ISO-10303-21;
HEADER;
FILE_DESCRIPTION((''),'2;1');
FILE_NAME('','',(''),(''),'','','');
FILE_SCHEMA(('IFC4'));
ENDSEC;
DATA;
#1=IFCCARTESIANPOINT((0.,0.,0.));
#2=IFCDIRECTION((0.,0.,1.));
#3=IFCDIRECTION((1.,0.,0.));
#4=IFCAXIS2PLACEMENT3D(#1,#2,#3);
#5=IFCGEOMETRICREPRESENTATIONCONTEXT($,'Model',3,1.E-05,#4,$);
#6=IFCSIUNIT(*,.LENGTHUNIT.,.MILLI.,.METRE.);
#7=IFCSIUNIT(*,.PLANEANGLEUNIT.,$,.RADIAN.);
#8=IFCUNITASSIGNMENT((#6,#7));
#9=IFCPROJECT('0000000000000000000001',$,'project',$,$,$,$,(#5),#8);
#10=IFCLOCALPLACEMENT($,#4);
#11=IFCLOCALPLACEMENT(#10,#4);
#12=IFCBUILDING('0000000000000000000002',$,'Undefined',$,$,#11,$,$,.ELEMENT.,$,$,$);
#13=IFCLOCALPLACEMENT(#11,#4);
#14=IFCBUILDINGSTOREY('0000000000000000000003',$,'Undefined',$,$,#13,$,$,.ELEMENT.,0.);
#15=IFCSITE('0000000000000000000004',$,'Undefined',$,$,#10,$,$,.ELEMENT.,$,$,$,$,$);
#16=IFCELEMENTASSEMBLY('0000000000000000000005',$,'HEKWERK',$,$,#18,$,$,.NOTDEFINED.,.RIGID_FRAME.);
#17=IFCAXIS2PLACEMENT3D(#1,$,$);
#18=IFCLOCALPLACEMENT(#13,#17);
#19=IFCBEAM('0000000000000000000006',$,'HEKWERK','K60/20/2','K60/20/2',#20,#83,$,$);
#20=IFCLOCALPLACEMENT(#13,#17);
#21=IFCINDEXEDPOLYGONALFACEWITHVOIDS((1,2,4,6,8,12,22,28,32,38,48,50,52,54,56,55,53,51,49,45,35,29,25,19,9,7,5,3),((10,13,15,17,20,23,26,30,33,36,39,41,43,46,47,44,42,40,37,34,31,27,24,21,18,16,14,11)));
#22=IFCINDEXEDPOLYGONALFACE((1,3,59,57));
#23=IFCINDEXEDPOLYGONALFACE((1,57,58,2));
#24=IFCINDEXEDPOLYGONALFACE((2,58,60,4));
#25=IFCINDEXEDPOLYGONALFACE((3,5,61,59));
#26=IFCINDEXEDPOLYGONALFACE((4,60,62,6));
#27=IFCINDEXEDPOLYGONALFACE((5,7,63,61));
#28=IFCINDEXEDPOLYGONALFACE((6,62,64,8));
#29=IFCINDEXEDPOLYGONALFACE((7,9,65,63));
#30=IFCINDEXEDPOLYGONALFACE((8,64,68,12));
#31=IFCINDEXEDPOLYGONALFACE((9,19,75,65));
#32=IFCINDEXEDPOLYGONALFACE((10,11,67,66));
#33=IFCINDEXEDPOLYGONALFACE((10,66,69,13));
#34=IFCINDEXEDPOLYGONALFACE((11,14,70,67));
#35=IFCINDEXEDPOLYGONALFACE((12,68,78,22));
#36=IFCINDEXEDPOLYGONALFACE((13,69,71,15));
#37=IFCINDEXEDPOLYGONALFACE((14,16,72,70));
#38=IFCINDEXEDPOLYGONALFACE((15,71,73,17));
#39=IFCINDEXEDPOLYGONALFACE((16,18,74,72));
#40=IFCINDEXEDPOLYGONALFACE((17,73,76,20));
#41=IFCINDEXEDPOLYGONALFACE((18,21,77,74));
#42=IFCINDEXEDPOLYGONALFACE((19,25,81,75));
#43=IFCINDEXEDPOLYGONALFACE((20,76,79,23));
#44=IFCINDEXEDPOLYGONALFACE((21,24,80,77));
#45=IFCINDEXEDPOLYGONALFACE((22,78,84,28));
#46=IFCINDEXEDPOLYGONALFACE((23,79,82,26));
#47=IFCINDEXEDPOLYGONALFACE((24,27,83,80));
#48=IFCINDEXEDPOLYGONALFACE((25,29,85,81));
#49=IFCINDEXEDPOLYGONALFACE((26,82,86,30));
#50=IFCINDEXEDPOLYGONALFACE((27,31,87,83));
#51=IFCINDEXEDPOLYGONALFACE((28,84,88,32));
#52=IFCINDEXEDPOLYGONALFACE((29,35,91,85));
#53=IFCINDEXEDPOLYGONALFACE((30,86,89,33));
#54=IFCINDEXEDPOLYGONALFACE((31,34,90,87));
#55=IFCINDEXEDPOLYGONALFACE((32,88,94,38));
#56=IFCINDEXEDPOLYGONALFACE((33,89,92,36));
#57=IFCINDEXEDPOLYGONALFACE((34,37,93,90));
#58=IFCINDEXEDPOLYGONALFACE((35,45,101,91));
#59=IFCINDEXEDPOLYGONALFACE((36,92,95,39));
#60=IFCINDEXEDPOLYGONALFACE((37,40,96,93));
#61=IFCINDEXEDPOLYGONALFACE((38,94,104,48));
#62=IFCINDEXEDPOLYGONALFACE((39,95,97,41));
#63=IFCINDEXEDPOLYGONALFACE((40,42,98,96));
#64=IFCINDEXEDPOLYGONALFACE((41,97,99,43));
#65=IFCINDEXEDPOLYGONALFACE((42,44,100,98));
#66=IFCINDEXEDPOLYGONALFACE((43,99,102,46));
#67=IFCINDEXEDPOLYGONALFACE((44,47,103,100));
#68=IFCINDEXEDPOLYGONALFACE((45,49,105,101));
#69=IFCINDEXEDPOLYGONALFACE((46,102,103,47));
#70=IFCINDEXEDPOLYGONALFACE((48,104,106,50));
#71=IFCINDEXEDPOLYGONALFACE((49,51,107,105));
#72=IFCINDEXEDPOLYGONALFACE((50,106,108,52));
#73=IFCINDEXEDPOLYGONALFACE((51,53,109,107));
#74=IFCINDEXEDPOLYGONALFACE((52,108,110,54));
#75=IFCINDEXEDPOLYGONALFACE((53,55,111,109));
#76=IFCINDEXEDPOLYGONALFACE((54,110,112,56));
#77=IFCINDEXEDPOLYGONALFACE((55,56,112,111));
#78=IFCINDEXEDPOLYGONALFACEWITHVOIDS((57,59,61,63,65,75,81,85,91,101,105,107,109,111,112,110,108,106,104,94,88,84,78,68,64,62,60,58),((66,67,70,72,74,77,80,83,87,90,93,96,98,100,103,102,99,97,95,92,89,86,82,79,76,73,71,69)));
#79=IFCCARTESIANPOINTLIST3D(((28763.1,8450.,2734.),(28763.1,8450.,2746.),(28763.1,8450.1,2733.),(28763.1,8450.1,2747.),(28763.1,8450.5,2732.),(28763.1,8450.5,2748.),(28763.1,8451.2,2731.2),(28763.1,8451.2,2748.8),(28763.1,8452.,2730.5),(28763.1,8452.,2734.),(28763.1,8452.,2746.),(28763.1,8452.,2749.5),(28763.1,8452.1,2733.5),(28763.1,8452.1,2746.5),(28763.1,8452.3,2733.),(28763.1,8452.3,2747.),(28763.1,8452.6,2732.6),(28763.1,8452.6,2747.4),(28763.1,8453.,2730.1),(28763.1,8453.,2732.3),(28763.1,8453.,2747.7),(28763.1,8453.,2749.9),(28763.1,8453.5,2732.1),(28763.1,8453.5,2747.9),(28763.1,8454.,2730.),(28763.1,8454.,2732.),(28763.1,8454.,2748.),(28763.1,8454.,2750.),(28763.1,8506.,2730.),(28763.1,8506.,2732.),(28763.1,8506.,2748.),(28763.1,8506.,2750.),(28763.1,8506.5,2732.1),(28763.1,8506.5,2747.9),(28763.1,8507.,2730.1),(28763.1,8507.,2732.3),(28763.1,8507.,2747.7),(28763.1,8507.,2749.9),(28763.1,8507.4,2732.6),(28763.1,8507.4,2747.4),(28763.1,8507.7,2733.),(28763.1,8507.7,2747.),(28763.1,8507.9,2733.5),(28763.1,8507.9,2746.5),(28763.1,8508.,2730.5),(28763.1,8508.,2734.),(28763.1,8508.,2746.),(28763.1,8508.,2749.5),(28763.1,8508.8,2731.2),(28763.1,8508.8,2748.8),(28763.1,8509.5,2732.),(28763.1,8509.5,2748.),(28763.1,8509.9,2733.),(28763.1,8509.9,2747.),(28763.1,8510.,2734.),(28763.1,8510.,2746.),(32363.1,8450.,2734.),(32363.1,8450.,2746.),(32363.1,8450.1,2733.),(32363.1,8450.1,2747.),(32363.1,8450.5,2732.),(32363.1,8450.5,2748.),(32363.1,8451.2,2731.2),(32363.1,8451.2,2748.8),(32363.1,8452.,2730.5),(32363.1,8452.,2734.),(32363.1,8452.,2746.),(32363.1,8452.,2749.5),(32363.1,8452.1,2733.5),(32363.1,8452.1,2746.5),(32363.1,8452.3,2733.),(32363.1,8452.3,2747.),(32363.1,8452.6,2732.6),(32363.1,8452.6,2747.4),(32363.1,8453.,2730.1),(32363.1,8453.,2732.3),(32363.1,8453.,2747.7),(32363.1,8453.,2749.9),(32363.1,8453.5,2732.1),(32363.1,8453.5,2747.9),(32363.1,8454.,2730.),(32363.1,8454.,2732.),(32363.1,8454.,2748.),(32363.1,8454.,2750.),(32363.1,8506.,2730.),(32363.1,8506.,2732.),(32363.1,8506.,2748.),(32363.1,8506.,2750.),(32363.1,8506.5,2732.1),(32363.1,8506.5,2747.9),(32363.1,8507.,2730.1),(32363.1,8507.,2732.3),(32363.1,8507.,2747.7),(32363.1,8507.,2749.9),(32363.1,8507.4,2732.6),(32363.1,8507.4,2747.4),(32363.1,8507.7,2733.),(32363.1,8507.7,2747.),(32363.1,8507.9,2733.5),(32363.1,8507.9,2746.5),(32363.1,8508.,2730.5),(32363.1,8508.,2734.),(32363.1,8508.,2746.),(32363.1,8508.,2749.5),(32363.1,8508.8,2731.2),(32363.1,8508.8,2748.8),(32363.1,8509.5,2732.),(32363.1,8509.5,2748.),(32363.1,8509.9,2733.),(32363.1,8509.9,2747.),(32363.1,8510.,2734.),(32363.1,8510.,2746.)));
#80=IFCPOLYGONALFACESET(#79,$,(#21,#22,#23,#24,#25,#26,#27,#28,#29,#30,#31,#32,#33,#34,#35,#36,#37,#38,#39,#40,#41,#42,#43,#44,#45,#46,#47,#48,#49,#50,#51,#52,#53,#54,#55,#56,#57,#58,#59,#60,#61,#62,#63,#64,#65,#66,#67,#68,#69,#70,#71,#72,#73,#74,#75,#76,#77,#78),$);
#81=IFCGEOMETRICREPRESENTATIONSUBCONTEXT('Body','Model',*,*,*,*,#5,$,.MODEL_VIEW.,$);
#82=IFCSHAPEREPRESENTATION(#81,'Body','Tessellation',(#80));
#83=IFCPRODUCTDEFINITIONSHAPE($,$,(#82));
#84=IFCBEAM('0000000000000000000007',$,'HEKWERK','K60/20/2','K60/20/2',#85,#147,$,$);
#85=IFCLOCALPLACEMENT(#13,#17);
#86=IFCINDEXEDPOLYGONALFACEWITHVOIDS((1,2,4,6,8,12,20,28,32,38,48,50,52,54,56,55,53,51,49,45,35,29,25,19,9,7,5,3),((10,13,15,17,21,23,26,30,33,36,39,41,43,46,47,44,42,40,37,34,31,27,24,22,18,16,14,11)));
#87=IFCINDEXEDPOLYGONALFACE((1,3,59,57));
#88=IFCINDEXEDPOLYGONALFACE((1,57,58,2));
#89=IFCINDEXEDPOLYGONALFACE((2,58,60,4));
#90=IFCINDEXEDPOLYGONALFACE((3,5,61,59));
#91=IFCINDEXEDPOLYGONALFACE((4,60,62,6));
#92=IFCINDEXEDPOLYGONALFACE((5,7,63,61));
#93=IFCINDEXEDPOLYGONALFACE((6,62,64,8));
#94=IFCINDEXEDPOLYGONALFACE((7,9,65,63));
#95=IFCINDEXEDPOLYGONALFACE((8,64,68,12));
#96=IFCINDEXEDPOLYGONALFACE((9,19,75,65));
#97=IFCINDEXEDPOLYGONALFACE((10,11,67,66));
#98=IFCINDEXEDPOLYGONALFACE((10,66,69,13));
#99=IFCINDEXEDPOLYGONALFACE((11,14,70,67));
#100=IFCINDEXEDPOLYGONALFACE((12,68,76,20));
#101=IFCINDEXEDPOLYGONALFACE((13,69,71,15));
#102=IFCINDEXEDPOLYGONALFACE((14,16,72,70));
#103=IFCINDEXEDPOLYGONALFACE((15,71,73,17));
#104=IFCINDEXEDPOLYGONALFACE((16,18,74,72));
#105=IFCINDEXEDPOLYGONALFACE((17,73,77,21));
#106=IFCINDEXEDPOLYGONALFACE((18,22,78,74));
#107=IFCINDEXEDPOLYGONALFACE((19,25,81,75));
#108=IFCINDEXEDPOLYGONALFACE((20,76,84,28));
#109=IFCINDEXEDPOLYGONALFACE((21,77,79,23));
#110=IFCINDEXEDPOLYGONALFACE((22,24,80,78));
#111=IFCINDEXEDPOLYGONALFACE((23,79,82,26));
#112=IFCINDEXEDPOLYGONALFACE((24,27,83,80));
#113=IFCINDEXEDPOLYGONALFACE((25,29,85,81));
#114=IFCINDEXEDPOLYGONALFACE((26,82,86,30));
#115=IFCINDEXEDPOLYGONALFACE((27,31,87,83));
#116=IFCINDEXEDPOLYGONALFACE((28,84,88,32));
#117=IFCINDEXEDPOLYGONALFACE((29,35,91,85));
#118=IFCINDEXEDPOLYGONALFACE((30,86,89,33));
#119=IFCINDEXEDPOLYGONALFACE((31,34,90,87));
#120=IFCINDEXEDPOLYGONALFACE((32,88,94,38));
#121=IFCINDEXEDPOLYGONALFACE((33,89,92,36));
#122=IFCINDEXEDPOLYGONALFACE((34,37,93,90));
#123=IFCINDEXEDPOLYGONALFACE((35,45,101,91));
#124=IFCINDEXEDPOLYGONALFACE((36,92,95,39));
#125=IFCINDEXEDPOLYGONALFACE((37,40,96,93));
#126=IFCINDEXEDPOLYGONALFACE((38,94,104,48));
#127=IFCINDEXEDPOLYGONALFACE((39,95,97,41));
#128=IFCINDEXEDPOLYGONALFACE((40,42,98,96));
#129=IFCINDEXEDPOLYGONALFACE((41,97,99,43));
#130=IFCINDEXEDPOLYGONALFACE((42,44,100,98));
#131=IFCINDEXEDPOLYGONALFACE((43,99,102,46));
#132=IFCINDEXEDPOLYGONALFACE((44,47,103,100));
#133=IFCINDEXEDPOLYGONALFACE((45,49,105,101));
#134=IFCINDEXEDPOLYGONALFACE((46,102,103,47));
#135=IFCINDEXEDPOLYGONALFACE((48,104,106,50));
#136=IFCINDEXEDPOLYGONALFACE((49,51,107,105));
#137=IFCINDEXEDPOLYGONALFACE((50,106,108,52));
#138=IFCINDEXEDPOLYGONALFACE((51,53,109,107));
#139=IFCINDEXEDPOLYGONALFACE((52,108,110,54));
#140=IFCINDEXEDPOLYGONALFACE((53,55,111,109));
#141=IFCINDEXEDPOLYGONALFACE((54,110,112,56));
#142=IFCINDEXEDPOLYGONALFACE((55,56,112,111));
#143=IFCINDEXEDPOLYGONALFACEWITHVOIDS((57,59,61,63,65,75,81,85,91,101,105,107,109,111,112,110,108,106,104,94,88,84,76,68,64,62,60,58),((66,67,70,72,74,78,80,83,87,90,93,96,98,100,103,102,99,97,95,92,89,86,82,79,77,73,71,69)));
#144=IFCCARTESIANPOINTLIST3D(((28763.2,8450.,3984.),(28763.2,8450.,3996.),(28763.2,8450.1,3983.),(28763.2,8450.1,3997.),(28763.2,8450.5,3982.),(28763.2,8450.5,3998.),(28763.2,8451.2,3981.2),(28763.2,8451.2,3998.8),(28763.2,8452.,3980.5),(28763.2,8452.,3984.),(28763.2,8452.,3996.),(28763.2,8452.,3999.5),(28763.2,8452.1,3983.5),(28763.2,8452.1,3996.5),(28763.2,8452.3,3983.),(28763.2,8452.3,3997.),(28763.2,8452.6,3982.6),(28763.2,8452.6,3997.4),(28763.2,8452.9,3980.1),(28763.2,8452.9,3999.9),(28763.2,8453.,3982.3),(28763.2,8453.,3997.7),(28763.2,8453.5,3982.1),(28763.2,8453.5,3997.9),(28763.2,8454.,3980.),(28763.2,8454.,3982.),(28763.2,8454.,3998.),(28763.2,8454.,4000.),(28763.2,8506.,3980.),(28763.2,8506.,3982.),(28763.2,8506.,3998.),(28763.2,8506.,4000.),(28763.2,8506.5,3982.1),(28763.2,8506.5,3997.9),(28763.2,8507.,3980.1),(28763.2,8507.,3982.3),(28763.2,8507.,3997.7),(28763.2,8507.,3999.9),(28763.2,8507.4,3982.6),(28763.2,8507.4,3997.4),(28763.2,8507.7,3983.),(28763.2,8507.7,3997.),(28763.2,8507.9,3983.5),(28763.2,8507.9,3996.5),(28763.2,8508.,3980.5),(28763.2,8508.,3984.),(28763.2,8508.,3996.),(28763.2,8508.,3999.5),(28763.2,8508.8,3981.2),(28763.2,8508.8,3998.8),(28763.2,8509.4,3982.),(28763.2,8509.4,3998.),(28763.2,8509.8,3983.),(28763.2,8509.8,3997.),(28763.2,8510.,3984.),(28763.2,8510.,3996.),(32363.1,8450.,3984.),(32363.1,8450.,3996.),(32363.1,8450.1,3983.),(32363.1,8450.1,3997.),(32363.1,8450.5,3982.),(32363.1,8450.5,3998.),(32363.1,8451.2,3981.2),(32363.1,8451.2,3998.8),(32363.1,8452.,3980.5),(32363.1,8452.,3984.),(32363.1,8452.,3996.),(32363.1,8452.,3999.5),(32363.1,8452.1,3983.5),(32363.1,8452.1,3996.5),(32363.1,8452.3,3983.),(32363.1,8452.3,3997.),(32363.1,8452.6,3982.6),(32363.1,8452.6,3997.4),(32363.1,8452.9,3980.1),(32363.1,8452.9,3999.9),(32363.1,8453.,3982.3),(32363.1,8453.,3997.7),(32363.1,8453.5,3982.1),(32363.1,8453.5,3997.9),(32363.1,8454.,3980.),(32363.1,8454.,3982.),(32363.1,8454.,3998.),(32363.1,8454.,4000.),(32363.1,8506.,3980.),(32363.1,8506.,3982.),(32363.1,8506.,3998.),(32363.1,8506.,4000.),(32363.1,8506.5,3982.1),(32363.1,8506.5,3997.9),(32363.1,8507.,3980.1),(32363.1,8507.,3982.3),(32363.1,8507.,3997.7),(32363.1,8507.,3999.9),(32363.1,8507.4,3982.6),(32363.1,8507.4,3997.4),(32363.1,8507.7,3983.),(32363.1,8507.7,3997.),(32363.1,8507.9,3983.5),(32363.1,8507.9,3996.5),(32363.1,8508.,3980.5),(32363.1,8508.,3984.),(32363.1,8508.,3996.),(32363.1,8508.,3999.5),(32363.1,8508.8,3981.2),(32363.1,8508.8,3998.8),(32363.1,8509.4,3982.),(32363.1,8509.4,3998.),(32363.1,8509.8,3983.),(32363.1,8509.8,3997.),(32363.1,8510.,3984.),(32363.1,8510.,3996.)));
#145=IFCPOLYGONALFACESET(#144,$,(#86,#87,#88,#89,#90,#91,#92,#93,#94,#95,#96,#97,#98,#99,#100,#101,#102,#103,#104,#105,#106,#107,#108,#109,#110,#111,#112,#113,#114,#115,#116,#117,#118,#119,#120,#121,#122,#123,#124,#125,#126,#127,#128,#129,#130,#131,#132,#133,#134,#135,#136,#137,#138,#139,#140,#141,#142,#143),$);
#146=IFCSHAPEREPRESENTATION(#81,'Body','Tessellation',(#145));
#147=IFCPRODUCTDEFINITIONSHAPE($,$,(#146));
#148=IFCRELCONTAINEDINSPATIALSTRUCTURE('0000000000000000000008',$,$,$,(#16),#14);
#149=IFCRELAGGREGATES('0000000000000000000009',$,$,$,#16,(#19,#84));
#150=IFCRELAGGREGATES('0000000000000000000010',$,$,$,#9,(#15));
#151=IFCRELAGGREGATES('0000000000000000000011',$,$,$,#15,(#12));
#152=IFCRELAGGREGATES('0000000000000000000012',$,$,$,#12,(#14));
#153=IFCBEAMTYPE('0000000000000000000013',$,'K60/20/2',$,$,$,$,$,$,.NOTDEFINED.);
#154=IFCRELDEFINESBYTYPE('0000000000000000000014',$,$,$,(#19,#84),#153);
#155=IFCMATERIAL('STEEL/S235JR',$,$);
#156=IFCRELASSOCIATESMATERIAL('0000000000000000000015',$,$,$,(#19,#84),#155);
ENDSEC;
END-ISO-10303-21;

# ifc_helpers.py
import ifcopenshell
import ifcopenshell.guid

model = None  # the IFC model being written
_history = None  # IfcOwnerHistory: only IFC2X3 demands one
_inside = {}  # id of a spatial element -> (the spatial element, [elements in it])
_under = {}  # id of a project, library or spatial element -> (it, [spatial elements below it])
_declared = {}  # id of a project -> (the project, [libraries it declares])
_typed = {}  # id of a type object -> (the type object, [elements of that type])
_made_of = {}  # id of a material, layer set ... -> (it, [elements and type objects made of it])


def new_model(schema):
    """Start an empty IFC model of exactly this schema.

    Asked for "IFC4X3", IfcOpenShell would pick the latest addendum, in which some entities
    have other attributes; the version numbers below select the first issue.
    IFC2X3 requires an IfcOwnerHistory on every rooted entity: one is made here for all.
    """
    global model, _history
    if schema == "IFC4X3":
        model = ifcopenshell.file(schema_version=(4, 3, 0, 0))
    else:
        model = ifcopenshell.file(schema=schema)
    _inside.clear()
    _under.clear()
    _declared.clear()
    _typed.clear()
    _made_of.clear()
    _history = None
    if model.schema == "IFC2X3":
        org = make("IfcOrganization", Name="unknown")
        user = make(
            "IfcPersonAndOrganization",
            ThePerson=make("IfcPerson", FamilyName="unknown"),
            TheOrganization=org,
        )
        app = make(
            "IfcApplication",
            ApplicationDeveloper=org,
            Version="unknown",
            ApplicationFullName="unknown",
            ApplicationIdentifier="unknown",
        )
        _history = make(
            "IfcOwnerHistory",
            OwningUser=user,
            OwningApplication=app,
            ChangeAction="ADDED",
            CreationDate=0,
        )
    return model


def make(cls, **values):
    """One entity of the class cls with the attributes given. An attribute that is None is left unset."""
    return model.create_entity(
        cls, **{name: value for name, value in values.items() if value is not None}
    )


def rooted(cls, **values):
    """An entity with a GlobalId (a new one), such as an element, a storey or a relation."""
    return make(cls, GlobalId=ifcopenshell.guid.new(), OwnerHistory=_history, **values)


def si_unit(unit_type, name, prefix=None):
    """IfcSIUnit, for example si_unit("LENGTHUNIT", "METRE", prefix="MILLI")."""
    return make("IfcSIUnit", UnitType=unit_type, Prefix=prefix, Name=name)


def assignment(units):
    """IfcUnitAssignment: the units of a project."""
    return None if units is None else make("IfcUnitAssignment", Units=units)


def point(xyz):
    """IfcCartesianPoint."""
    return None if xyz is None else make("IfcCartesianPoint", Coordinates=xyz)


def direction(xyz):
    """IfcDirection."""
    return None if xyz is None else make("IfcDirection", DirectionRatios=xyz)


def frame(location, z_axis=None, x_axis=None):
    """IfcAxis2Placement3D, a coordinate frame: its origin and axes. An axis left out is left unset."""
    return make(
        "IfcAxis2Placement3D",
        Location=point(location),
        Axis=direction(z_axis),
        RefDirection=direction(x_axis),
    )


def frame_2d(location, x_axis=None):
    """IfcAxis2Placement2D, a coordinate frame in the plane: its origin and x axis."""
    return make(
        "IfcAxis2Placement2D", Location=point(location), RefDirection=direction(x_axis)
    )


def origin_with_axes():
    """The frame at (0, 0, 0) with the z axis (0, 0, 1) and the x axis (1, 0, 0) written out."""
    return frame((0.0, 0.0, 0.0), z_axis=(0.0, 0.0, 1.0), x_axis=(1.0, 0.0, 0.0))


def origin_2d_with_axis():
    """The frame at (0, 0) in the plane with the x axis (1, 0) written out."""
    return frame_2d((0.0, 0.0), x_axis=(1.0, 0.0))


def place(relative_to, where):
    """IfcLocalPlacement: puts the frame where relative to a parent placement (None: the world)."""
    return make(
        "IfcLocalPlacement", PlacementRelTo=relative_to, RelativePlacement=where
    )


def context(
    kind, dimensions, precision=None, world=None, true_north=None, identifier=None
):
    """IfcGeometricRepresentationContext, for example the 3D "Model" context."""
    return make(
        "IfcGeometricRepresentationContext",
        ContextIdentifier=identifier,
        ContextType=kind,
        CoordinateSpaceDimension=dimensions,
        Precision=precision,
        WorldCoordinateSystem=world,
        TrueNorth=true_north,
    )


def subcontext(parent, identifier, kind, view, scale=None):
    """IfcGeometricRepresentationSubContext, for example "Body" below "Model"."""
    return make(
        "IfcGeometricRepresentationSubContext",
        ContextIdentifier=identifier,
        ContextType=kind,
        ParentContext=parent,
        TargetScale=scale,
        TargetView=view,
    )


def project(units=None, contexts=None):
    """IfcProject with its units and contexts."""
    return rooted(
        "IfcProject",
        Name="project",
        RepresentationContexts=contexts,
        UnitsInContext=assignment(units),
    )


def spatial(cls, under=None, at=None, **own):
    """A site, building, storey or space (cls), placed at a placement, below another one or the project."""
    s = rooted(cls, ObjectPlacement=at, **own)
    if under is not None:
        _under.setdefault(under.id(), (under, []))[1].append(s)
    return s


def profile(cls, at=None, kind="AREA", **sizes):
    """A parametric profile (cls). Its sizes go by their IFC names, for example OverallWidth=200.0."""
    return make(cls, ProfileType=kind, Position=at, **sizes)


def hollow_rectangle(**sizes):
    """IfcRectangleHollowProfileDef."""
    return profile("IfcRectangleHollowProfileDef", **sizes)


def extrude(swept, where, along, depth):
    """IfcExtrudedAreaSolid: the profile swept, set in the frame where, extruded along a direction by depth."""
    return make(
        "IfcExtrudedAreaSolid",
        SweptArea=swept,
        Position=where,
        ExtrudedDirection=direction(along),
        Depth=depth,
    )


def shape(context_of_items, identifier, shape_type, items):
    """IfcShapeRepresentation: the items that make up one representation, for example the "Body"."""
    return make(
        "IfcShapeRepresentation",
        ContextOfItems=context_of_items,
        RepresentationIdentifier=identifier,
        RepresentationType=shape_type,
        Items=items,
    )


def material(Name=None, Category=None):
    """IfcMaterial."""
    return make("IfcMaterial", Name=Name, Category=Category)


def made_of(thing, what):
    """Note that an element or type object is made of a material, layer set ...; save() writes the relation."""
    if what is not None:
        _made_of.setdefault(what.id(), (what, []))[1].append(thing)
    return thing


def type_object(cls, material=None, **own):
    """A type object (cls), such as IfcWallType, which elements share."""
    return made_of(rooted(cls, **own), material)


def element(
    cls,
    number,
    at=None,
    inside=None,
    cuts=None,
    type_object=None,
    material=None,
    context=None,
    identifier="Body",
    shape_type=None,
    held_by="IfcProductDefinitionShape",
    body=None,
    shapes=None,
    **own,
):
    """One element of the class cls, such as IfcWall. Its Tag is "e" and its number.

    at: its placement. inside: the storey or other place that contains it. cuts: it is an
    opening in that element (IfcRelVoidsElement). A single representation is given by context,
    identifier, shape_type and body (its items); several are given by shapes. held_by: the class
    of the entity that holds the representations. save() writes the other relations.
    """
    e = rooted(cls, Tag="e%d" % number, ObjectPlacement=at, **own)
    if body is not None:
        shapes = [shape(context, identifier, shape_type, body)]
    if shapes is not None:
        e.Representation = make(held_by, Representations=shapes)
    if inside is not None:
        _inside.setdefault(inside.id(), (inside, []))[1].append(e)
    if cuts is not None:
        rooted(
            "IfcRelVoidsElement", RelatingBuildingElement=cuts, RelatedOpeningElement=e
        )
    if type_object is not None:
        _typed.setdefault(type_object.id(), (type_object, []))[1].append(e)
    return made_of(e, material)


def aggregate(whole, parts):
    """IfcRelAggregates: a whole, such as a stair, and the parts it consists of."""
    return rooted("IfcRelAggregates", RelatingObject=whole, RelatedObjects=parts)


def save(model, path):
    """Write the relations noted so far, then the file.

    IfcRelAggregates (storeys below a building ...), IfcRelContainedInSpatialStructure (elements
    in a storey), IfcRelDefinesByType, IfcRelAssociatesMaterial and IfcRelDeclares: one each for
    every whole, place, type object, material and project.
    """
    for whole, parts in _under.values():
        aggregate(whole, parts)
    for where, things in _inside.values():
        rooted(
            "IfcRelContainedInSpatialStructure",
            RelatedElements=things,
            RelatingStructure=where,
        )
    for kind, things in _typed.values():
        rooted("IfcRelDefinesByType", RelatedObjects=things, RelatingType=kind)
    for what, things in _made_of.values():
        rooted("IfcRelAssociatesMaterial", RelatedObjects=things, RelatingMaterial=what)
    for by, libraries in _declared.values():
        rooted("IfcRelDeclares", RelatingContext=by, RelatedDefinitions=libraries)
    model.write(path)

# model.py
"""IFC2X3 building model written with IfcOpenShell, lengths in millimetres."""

from ifc_helpers import new_model, si_unit, frame, origin_with_axes, origin_2d_with_axis, place, context, subcontext, project, spatial, hollow_rectangle, extrude, material, type_object, element, aggregate, save


model = new_model("IFC2X3")

# Units and contexts
model_context = context("Model", 3, precision=1e-05, world=origin_with_axes())
body_context = subcontext(model_context, "Body", "Model", "MODEL_VIEW")
ifc_project = project(units=[si_unit("LENGTHUNIT", "METRE", prefix="MILLI"), si_unit("PLANEANGLEUNIT", "RADIAN")], contexts=[model_context])

# Site, building, storey
site_placement = place(None, origin_with_axes())
site = spatial("IfcSite", under=ifc_project, at=site_placement, Name="Undefined", CompositionType="ELEMENT")
building_placement = place(site_placement, origin_with_axes())
building = spatial("IfcBuilding", under=site, at=building_placement, Name="Undefined", CompositionType="ELEMENT")
storey_placement = place(building_placement, origin_with_axes())
storey = spatial("IfcBuildingStorey", under=building, at=storey_placement, Name="Undefined", CompositionType="ELEMENT", Elevation=0.0)

# Element assembly, beams
assembly_1_placement = place(storey_placement, origin_with_axes())
assembly_1 = element("IfcElementAssembly", 1, at=assembly_1_placement, inside=storey, Name="HEKWERK", AssemblyPlace="NOTDEFINED", PredefinedType="RIGID_FRAME")
ifc_material_1 = material(Name="STEEL/S235JR")
beam_type_1 = type_object("IfcBeamType", Name="K60/20/2", PredefinedType="NOTDEFINED")
beam_1_placement = place(assembly_1_placement, frame((28763.1, 8480.0, 2740.0), z_axis=(0.0, 1.0, 0.0), x_axis=(1.0, 0.0, 0.0)))
beam_1 = element("IfcBeam", 2, at=beam_1_placement, type_object=beam_type_1, material=ifc_material_1, Name="HEKWERK", Description="K60/20/2", ObjectType="K60/20/2", context=body_context, shape_type="SweptSolid", body=[
    extrude(hollow_rectangle(XDim=20.0, YDim=60.0, WallThickness=2.0, InnerFilletRadius=2.0, OuterFilletRadius=4.0, at=origin_2d_with_axis()), frame((3600.0, 0.0, 0.0), z_axis=(-1.0, 0.0, 0.0), x_axis=(0.0, -1.0, 0.0)), (0.0, 0.0, 1.0), 3600.0),
])
beam_2_placement = place(assembly_1_placement, frame((28763.2, 8480.0, 3990.0), z_axis=(0.0, 1.0, 0.0), x_axis=(1.0, 0.0, 0.0)))
beam_2 = element("IfcBeam", 3, at=beam_2_placement, type_object=beam_type_1, material=ifc_material_1, Name="HEKWERK", Description="K60/20/2", ObjectType="K60/20/2", context=body_context, shape_type="SweptSolid", body=[
    extrude(hollow_rectangle(XDim=20.0, YDim=60.0, WallThickness=2.0, InnerFilletRadius=2.0, OuterFilletRadius=4.0, at=origin_2d_with_axis()), frame((3600.0, 0.0, 0.0), z_axis=(-1.0, 0.0, 0.0), x_axis=(0.0, -1.0, 0.0)), (0.0, 0.0, 1.0), 3600.0),
])

aggregate(assembly_1, [beam_1, beam_2])

save(model, "model.ifc")
